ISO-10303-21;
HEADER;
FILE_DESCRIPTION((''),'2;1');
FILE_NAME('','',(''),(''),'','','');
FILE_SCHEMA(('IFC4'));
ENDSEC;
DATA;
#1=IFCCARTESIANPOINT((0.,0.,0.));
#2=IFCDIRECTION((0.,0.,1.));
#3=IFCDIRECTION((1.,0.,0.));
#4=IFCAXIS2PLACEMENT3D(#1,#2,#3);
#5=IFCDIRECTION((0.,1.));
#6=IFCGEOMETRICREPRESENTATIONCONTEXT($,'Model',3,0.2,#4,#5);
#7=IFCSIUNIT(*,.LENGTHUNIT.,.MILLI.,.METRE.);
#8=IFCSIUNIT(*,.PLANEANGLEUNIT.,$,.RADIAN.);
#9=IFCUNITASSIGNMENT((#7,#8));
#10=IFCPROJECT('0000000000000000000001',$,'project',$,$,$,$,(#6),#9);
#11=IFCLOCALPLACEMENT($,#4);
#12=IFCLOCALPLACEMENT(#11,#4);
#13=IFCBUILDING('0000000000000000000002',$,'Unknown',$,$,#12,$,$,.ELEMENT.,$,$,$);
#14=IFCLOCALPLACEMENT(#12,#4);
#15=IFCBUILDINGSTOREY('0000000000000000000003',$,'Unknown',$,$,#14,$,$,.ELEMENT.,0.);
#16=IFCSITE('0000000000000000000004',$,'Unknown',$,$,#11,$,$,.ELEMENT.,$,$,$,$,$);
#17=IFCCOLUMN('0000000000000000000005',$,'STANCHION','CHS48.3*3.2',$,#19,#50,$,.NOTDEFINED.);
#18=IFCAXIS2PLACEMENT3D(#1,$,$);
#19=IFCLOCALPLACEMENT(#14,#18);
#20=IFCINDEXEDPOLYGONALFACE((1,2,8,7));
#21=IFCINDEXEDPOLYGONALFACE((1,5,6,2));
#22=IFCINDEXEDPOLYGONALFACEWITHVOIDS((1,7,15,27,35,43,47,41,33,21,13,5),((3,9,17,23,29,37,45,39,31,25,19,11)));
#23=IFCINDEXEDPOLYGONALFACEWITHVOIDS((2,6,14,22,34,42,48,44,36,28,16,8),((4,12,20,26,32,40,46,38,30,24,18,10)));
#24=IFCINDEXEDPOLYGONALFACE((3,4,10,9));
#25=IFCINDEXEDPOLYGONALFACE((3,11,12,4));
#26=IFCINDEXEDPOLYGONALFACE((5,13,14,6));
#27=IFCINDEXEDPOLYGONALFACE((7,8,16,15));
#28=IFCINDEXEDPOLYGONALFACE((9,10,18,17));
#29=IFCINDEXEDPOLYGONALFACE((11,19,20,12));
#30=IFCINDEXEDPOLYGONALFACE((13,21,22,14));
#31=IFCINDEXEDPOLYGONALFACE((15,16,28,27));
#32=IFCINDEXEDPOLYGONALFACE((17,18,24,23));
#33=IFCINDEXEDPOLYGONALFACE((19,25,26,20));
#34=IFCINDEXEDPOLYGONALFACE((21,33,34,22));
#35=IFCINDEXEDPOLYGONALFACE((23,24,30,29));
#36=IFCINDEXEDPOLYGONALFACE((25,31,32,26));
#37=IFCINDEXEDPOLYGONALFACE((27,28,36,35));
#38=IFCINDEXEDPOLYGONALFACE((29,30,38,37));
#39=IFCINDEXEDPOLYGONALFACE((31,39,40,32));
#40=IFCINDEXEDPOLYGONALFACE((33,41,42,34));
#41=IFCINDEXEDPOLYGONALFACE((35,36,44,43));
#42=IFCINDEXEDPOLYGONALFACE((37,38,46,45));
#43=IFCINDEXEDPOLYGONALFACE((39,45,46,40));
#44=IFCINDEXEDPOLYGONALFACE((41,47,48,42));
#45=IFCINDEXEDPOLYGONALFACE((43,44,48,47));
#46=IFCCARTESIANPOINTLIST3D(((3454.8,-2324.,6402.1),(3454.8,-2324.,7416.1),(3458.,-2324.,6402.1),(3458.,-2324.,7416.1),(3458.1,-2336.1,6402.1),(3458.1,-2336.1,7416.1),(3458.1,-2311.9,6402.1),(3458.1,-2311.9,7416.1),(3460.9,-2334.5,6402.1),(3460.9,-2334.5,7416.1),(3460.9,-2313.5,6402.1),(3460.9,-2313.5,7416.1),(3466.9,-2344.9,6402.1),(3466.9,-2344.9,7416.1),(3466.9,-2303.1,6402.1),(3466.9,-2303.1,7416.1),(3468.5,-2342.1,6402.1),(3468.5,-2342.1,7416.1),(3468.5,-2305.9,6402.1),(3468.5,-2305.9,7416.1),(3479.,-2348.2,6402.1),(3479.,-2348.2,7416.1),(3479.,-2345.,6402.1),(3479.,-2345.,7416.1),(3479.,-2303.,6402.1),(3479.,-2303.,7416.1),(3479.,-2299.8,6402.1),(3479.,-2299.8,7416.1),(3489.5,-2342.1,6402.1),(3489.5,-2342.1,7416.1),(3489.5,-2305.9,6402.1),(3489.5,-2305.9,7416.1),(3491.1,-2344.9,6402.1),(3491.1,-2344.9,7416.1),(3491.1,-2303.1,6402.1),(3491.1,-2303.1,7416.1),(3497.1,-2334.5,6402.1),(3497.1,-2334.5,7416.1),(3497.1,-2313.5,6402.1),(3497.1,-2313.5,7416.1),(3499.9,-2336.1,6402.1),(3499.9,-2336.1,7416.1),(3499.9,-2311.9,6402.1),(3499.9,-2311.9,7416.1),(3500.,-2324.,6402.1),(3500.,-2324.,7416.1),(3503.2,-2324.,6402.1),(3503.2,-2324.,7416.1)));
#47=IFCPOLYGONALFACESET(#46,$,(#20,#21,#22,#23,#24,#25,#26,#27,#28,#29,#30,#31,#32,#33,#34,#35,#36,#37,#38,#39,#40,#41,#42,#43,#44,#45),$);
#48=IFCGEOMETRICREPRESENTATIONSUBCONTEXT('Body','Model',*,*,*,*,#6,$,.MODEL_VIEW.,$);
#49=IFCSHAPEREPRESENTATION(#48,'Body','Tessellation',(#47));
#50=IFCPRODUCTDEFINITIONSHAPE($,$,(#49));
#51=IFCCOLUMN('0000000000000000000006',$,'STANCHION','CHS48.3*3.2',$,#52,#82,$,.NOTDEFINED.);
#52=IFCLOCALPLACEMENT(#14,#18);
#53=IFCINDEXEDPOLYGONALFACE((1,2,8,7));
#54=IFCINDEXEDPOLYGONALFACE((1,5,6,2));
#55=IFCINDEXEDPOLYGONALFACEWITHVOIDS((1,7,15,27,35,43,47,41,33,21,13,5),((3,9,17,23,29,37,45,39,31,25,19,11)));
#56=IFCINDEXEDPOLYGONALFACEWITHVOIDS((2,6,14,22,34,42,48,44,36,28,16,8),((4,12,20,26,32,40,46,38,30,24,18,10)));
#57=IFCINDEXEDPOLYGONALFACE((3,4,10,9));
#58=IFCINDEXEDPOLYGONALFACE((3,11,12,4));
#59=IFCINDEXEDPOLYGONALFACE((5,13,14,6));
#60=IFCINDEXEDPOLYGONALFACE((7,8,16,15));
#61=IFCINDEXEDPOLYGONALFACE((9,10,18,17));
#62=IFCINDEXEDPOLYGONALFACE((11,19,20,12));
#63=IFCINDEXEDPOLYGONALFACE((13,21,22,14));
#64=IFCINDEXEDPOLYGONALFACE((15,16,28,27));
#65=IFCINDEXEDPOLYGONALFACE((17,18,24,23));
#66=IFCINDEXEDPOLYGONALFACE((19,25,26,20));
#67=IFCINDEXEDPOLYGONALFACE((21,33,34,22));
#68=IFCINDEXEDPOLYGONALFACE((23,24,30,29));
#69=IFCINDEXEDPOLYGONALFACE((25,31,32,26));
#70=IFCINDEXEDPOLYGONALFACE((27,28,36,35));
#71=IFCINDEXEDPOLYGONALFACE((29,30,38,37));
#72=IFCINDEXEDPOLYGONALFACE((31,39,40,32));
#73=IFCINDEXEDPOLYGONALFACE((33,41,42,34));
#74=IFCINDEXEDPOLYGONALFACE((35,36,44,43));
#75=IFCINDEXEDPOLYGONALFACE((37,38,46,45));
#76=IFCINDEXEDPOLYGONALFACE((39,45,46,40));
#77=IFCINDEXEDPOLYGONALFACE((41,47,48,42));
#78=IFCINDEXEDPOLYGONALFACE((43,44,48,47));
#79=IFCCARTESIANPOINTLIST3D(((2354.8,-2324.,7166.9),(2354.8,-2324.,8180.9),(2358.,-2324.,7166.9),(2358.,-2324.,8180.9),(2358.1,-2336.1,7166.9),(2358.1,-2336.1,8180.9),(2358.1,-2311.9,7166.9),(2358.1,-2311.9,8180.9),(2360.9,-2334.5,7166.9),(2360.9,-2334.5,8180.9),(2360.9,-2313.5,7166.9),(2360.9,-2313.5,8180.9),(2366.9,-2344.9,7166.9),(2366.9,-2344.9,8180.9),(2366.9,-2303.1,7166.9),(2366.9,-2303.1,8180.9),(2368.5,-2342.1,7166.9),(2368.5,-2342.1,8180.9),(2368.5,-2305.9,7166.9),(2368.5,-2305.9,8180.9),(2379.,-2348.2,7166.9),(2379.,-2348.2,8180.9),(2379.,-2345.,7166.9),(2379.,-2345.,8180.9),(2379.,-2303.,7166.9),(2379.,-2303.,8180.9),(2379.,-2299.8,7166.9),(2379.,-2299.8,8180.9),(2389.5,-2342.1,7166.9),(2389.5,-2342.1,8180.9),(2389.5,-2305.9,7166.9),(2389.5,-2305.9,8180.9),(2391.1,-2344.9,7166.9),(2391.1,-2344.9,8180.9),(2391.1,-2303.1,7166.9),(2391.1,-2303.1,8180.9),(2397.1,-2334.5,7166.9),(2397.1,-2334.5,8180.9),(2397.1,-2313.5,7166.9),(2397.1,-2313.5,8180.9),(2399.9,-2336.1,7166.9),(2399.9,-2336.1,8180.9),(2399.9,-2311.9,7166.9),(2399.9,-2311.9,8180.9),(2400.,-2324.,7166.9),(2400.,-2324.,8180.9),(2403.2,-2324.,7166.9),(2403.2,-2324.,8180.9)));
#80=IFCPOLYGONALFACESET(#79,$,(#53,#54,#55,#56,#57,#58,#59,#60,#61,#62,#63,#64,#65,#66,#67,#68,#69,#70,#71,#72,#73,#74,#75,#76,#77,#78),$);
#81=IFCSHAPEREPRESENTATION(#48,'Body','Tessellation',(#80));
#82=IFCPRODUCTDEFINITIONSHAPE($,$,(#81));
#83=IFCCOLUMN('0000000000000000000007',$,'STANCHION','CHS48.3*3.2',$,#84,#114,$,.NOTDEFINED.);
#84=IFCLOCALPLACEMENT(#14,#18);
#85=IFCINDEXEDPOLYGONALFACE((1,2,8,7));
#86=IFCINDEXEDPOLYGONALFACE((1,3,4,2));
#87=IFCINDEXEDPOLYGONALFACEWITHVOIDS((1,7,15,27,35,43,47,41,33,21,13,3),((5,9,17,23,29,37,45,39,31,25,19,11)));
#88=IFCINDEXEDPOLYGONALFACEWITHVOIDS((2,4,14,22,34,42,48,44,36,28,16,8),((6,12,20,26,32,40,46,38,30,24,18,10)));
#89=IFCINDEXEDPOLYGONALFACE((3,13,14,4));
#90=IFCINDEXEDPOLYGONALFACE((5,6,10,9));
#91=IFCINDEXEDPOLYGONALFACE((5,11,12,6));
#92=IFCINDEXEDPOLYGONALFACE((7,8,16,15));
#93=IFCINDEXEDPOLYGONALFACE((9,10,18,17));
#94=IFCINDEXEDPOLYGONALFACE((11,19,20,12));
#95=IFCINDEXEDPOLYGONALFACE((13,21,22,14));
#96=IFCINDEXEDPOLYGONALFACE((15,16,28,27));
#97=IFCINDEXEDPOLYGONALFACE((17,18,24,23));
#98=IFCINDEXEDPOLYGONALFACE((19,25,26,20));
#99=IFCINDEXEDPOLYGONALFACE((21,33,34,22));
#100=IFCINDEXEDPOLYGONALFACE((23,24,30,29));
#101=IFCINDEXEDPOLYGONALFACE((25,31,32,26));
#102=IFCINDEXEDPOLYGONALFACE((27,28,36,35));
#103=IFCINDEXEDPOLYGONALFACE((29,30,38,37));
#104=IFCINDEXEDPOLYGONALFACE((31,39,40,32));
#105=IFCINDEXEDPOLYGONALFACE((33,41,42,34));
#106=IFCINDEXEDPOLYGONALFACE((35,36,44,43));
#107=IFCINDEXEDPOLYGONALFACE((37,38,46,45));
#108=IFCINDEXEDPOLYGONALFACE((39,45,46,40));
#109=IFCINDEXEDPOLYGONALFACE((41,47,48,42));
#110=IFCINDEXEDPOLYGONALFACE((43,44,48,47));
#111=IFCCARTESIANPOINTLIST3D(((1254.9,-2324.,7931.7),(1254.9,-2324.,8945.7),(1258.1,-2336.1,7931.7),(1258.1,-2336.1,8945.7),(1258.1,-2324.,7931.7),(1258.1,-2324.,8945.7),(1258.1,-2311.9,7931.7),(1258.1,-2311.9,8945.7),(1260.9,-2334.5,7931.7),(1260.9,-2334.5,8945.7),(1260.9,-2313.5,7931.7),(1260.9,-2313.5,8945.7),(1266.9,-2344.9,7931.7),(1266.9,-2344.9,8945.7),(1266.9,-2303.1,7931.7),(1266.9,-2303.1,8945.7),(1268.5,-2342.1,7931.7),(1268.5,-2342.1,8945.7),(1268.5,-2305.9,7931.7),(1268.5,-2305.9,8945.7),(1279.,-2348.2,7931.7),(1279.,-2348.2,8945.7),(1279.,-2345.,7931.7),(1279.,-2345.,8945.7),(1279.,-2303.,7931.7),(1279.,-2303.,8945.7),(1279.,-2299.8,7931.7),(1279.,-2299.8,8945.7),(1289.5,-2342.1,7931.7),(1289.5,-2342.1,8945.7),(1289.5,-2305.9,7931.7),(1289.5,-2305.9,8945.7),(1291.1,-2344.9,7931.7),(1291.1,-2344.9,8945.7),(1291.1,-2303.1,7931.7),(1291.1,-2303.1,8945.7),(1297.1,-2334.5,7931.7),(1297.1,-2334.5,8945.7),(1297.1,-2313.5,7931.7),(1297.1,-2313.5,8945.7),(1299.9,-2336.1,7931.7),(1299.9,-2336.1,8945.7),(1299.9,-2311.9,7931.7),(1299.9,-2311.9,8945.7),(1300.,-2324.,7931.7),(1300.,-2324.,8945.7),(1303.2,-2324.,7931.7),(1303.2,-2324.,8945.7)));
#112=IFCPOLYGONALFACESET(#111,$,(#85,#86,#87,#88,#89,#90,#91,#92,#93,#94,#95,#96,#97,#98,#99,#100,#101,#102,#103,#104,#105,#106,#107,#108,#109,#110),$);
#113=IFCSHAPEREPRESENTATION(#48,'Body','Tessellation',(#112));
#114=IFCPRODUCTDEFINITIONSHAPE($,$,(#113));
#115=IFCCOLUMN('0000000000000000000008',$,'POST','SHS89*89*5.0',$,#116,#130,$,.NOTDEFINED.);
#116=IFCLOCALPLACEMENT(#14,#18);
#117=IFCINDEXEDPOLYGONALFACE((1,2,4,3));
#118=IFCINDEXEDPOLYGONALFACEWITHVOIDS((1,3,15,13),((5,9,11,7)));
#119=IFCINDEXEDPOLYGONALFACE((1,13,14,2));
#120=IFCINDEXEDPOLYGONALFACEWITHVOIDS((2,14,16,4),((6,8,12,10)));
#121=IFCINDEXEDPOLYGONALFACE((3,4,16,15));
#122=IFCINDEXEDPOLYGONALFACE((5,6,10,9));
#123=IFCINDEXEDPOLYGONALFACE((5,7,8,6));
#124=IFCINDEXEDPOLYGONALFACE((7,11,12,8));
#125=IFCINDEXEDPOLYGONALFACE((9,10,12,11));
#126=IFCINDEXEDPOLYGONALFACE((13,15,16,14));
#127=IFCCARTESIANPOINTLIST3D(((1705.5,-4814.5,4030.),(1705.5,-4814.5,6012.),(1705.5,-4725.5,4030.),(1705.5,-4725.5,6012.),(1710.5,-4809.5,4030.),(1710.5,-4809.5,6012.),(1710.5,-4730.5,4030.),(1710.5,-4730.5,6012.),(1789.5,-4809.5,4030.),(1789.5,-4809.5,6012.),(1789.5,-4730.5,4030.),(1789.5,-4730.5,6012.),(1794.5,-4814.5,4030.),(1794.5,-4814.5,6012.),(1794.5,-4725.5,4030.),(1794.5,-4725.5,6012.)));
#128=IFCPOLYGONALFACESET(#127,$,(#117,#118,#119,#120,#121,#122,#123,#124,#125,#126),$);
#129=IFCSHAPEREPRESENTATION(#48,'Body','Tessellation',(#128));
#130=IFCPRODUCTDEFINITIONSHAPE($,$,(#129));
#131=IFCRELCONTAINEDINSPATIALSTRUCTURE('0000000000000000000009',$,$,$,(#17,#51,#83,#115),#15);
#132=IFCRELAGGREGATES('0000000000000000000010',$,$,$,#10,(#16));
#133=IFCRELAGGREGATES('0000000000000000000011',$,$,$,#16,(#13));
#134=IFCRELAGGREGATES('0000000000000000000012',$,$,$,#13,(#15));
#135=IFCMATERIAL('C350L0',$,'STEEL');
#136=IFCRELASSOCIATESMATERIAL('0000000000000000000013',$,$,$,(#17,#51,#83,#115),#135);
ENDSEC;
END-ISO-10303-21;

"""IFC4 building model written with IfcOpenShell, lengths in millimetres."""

from ifc_helpers import new_model, si_unit, direction, frame, origin_with_axes, place, context, subcontext, project, spatial, line, indexed_curve, outline, extrude, material, element, save


model = new_model("IFC4")

# Units and contexts
model_context = context("Model", 3, precision=0.2, world=origin_with_axes(), true_north=direction((0.0, 1.0)))
body_context = subcontext(model_context, "Body", "Model", "MODEL_VIEW")
ifc_project = project(units=[si_unit("LENGTHUNIT", "METRE", prefix="MILLI"), si_unit("PLANEANGLEUNIT", "RADIAN")], contexts=[model_context])

# Site, building, storey
site_placement = place(None, origin_with_axes())
site = spatial("IfcSite", under=ifc_project, at=site_placement, Name="Unknown", CompositionType="ELEMENT")
building_placement = place(site_placement, origin_with_axes())
building = spatial("IfcBuilding", under=site, at=building_placement, Name="Unknown", CompositionType="ELEMENT")
storey_placement = place(building_placement, origin_with_axes())
storey = spatial("IfcBuildingStorey", under=building, at=storey_placement, Name="Unknown", CompositionType="ELEMENT", Elevation=0.0)

# Columns
ifc_material_1 = material(Name="C350L0", Category="STEEL")
for number, where, z_axis, x_axis, name in (
    (1, (3479.0, -2324.0, 6402.1), (-1.0, 0.0, 0.0), (0.0, 0.0, 1.0), "STANCHION"),
    (2, (2379.0, -2324.0, 7166.9), (-1.0, 0.0, 0.0), (0.0, 0.0, 1.0), "STANCHION"),
    (3, (1279.0, -2324.0, 7931.7), (-1.0, 0.0, 0.0), (0.0, 0.0, 1.0), "STANCHION"),
):
    element("IfcColumn", number, at=place(storey_placement, frame(where, z_axis=z_axis, x_axis=x_axis)), inside=storey, material=ifc_material_1, Name=name, Description="CHS48.3*3.2", PredefinedType="NOTDEFINED", context=body_context, shape_type="SolidModel", body=[
        extrude(outline(indexed_curve([(24.1, 0.0), (20.9, 12.1), (12.1, 20.9), (0.0, 24.1), (-12.1, 20.9), (-20.9, 12.1), (-24.1, 0.0), (-20.9, -12.1), (-12.1, -20.9), (0.0, -24.1), (12.1, -20.9), (20.9, -12.1)], segments=[line(1, 2, 3, 4, 5, 6, 7, 8, 9, 10, 11, 12, 1)]), holes=[indexed_curve([(20.9, 0.0), (18.1, -10.5), (10.5, -18.1), (0.0, -20.9), (-10.5, -18.1), (-18.1, -10.5), (-20.9, 0.0), (-18.1, 10.5), (-10.5, 18.1), (0.0, 20.9), (10.5, 18.1), (18.1, 10.5)], segments=[line(1, 2, 3, 4, 5, 6, 7, 8, 9, 10, 11, 12, 1)])]), frame((0.0, 0.0, 0.0), z_axis=(-1.0, 0.0, 0.0), x_axis=(0.0, 0.0, 1.0)), (0.0, 0.0, -1.0), 1014.0),
    ])
column_placement = place(storey_placement, frame((1750.0, -4770.0, 4030.0), z_axis=(-1.0, 0.0, 0.0), x_axis=(0.0, 0.0, 1.0)))
element("IfcColumn", 4, at=column_placement, inside=storey, material=ifc_material_1, Name="POST", Description="SHS89*89*5.0", PredefinedType="NOTDEFINED", context=body_context, shape_type="SolidModel", body=[
    extrude(outline(indexed_curve([(-44.5, -44.5), (44.5, -44.5), (44.5, 44.5), (-44.5, 44.5)], segments=[line(1, 2, 3, 4, 1)]), holes=[indexed_curve([(-39.5, -39.5), (-39.5, 39.5), (39.5, 39.5), (39.5, -39.5)], segments=[line(1, 2, 3, 4, 1)])]), frame((0.0, 0.0, 0.0), z_axis=(-1.0, 0.0, 0.0), x_axis=(0.0, 0.0, 1.0)), (0.0, 0.0, -1.0), 1982.0),
])

save(model, "model.ifc")
